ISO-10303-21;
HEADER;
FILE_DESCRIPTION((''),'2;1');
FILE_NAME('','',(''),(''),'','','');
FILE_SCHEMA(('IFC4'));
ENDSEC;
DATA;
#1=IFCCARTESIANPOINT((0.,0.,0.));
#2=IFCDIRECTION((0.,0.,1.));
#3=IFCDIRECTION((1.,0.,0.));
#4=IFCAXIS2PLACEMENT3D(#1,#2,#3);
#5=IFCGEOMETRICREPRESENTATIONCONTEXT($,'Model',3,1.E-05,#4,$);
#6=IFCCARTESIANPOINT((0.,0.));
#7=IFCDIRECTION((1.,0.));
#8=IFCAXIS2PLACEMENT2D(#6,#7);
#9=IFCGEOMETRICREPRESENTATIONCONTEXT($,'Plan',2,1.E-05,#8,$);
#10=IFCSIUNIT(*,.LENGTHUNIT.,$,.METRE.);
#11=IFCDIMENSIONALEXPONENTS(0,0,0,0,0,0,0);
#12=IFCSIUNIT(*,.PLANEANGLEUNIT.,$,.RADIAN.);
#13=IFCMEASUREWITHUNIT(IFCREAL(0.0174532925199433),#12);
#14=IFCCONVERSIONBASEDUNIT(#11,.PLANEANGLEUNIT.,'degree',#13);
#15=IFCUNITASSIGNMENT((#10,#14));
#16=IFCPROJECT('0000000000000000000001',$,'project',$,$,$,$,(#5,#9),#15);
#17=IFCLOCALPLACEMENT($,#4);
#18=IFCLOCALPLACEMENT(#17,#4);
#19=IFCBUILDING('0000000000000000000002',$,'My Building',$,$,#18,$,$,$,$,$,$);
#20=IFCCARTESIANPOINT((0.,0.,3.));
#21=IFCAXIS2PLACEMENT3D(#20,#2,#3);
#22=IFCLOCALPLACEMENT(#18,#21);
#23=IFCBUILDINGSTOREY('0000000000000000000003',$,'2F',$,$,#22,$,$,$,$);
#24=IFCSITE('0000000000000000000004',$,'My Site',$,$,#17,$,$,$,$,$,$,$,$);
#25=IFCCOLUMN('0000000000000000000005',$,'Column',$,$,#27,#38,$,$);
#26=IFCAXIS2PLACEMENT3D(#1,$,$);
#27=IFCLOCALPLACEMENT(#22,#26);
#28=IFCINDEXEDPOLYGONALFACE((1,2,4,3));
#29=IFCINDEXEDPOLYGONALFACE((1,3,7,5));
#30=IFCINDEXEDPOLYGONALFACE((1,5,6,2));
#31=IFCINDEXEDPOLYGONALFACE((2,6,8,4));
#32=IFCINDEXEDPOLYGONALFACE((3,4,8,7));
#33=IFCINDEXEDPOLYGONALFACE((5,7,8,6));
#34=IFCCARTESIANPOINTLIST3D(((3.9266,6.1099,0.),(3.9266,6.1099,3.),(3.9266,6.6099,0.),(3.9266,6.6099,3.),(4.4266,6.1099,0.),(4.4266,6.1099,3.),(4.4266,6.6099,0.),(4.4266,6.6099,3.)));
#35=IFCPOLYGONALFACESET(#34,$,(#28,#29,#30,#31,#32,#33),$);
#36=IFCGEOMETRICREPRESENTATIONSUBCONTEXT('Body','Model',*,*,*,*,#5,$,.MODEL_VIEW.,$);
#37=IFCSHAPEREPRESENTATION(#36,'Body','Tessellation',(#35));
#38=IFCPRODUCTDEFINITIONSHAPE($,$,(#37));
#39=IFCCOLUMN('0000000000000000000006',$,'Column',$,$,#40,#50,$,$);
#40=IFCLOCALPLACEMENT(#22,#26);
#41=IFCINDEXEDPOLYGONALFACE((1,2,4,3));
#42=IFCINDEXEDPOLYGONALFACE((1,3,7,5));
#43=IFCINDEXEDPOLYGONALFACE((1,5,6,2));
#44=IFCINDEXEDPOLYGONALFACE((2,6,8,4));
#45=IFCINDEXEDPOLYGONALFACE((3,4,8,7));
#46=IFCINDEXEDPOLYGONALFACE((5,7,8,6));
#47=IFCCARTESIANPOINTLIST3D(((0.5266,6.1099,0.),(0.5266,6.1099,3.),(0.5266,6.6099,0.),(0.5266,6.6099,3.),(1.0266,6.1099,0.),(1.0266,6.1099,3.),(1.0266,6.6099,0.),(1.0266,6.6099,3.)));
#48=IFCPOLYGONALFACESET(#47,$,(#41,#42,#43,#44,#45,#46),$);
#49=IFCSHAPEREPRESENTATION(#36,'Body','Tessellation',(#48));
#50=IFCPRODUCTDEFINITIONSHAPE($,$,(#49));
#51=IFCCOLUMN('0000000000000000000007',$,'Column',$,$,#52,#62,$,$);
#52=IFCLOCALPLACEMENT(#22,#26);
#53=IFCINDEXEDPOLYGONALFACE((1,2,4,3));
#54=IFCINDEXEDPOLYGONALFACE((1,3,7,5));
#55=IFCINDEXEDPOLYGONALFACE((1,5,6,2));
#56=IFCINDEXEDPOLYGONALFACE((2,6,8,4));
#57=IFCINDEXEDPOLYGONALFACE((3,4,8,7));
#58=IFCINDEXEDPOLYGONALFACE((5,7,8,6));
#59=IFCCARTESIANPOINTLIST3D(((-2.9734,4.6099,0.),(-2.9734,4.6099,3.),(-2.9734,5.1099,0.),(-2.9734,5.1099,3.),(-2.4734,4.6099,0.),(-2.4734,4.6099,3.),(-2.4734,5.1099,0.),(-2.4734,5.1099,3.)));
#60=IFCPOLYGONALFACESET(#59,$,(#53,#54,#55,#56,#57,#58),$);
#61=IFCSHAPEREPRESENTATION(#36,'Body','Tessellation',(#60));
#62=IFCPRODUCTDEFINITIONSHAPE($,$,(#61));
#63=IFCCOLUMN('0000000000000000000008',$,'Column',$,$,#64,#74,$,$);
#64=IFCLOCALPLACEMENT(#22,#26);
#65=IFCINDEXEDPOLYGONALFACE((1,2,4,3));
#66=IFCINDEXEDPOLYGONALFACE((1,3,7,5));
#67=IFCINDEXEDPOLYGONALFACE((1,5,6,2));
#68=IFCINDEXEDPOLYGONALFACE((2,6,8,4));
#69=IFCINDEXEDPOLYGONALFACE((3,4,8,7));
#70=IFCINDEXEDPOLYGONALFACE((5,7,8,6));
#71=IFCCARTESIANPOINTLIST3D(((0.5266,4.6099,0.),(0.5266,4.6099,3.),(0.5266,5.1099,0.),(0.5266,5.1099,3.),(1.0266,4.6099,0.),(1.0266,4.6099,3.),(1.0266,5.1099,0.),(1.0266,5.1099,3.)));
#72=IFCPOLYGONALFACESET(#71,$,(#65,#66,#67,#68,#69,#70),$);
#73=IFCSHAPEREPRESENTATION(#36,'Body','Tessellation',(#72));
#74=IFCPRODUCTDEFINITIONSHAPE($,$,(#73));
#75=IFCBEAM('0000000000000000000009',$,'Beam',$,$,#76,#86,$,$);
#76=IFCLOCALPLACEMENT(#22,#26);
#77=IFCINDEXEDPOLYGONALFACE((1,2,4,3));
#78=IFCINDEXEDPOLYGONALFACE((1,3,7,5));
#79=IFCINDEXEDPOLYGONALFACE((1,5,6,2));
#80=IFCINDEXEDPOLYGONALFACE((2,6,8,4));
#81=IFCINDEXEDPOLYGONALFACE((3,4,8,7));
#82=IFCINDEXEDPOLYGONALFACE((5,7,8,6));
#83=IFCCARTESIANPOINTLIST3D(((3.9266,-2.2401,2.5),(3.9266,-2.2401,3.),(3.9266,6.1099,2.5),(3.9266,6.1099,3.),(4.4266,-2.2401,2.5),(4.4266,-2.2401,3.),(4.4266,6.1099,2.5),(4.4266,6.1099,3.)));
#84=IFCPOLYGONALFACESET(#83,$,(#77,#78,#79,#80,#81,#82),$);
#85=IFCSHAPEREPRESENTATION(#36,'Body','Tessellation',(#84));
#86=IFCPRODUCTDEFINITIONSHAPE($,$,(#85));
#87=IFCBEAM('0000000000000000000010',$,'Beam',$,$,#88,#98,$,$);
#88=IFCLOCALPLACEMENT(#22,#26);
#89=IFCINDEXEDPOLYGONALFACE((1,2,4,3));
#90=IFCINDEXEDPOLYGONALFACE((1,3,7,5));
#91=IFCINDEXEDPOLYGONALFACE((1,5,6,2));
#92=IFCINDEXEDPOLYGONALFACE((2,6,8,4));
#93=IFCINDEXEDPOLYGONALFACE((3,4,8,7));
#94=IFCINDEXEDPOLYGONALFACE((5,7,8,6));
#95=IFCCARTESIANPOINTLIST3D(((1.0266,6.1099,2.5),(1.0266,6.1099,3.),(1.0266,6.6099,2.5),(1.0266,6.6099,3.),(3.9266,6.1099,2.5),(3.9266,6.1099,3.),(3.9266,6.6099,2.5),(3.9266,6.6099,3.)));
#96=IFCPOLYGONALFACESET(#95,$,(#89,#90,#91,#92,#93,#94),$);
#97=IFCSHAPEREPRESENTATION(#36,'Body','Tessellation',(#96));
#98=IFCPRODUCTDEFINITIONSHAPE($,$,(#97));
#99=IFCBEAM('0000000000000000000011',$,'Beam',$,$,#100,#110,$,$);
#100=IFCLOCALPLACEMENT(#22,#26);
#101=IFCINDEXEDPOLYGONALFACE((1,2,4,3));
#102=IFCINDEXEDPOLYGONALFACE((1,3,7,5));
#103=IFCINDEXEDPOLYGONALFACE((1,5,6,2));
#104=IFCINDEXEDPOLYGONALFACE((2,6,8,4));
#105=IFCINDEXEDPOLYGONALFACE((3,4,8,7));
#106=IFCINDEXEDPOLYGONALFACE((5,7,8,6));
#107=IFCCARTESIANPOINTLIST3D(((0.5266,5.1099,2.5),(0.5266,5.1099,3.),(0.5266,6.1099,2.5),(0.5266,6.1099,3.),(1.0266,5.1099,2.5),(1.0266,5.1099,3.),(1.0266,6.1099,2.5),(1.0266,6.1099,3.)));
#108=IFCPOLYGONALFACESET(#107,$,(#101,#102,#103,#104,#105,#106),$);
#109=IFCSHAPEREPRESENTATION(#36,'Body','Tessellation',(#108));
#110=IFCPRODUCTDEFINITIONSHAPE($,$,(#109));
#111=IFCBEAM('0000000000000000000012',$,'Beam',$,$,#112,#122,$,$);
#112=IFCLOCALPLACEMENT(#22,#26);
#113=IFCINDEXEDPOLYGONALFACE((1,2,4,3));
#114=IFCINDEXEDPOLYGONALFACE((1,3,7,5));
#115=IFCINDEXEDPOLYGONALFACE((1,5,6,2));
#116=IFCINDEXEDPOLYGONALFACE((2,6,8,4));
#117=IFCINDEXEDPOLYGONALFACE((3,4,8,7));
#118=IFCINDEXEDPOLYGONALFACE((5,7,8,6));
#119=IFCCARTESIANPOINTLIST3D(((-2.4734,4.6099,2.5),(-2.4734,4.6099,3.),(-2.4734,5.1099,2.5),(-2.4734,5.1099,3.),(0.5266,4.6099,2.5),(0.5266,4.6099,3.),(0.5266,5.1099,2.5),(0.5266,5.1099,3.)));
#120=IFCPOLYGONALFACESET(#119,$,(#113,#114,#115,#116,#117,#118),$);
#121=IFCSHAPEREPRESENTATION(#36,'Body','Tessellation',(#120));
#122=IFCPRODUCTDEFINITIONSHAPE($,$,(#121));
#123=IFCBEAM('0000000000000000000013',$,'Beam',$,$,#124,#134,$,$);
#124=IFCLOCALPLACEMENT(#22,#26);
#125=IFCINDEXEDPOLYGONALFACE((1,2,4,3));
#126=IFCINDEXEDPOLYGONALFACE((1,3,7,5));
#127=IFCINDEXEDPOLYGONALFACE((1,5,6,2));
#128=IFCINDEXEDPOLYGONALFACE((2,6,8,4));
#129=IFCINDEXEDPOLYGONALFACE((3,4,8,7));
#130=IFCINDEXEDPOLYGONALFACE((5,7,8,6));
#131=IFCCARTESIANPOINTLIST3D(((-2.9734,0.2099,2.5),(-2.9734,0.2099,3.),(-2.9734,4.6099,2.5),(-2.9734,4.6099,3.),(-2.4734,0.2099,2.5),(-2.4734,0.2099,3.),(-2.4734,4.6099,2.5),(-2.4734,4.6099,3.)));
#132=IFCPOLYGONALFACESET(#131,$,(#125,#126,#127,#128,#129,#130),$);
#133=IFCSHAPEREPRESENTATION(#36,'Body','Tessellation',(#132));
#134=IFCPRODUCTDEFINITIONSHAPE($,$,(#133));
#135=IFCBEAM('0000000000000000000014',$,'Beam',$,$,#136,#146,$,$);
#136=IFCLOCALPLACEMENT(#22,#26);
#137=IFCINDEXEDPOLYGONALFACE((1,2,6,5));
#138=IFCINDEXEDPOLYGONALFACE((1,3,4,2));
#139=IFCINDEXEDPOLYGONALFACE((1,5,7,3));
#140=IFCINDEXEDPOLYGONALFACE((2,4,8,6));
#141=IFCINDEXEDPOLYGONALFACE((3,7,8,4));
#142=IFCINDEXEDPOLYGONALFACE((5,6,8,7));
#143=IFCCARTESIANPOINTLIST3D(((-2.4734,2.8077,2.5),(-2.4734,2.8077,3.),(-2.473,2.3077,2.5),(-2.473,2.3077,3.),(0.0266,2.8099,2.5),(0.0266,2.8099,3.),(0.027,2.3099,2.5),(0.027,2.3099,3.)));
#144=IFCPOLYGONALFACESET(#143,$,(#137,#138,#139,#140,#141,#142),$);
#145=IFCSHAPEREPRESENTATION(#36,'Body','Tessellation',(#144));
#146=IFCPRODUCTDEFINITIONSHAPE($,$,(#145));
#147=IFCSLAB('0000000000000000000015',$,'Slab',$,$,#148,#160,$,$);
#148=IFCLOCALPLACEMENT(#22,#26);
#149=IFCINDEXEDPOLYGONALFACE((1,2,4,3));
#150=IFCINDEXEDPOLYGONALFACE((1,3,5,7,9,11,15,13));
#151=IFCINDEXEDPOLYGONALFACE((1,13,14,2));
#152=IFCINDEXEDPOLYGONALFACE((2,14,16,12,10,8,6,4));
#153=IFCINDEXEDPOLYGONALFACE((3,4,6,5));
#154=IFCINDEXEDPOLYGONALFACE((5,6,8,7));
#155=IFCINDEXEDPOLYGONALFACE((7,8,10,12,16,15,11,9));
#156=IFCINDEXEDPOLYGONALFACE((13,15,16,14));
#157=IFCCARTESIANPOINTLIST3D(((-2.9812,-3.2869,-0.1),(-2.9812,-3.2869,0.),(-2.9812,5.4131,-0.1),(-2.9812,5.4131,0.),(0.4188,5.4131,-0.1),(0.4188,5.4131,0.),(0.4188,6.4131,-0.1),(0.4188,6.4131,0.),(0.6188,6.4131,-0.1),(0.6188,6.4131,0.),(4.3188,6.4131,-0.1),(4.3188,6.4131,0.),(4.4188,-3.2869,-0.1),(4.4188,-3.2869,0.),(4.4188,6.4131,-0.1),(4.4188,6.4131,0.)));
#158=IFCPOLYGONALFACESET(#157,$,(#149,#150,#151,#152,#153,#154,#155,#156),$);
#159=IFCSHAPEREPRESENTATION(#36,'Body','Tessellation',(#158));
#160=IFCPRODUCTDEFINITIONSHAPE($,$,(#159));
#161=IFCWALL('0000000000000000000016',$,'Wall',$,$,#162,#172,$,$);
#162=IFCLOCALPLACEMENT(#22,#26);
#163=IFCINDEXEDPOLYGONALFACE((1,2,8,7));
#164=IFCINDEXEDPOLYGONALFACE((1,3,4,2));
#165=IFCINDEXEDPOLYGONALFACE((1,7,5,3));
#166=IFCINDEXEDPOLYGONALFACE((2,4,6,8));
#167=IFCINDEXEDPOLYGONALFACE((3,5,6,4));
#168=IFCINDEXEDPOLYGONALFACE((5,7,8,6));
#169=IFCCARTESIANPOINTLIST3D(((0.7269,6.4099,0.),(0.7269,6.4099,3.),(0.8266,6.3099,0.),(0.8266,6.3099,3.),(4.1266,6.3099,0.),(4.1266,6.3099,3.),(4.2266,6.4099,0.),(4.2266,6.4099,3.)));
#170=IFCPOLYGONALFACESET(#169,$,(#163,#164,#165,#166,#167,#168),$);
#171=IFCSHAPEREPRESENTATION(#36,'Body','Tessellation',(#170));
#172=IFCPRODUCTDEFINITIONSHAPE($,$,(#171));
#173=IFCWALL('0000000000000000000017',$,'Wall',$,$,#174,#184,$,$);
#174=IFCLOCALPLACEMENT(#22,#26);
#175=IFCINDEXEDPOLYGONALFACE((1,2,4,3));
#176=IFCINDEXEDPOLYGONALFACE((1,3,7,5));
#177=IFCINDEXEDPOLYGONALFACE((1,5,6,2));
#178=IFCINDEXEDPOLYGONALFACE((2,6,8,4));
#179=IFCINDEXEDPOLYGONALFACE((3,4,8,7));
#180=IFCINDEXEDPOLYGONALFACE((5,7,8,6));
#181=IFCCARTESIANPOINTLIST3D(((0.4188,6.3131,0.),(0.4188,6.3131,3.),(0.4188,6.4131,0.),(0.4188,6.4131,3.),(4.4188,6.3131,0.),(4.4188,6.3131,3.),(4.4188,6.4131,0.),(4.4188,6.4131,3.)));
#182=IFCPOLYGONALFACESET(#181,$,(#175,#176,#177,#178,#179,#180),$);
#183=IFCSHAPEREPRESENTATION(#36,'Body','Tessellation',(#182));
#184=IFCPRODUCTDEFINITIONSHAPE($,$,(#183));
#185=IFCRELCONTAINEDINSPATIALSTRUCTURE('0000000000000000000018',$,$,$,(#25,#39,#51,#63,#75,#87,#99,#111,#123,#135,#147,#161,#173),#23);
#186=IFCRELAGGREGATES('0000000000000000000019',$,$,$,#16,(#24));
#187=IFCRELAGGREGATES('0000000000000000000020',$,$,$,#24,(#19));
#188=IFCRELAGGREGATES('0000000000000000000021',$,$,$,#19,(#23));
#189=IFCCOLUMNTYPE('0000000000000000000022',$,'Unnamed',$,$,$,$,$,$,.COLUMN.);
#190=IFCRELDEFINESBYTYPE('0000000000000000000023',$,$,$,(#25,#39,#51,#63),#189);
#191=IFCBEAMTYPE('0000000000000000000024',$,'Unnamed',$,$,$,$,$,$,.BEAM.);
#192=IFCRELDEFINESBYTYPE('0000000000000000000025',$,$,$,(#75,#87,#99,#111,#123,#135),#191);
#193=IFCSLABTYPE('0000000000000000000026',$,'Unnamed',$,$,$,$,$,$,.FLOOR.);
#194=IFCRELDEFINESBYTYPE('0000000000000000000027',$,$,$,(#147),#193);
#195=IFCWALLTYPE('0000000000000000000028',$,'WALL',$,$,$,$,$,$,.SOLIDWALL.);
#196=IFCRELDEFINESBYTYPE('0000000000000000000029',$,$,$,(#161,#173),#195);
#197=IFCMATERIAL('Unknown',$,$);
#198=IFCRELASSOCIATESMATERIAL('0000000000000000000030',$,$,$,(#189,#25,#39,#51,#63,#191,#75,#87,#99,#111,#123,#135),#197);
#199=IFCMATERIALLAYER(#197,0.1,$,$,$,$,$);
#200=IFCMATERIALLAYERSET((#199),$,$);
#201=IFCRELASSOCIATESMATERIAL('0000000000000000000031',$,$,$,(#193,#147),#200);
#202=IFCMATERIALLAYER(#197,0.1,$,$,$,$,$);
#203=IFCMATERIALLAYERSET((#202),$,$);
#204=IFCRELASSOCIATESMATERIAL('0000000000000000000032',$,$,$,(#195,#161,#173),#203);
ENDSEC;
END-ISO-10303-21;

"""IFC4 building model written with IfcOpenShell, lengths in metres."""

from ifc_helpers import new_model, entity, si_unit, converted_unit, frame, origin_with_axes, origin_2d_with_axis, place, context, subcontext, project, spatial, line, indexed_curve, rectangle, outline, extrude, material, layer, layer_set, layer_usage, material_profile, profile_set, profile_usage, type_object, element, save


model = new_model("IFC4")

# Units and contexts
model_context = context("Model", 3, precision=1e-05, world=origin_with_axes())
plan_context = context("Plan", 2, precision=1e-05, world=origin_2d_with_axis())
body_context_1 = subcontext(model_context, "Body", "Model", "MODEL_VIEW")
ifc_project = project(units=[si_unit("LENGTHUNIT", "METRE"), converted_unit("PLANEANGLEUNIT", "degree", entity("IfcReal", 0.0174532925199433), si_unit("PLANEANGLEUNIT", "RADIAN"), dimensions=[0, 0, 0, 0, 0, 0, 0])], contexts=[model_context, plan_context])

# Site, building, storey
site_placement = place(None, origin_with_axes())
site = spatial("IfcSite", under=ifc_project, at=site_placement, Name="My Site")
building_placement = place(site_placement, origin_with_axes())
building = spatial("IfcBuilding", under=site, at=building_placement, Name="My Building")
storey_placement = place(building_placement, frame((0.0, 0.0, 3.0), z_axis=(0.0, 0.0, 1.0), x_axis=(1.0, 0.0, 0.0)))
storey = spatial("IfcBuildingStorey", under=building, at=storey_placement, Name="2F")

# Columns
ifc_material = material(Name="Unknown")
ifc_material_profile_1 = material_profile(ifc_material, rectangle(XDim=0.5, YDim=0.5))
ifc_profile_set_1 = profile_set([ifc_material_profile_1])
ifc_profile_usage_1 = profile_usage(ifc_profile_set_1, cardinal=5)
column_type = type_object("IfcColumnType", Name="Unnamed", PredefinedType="COLUMN", material=ifc_profile_set_1)
column_1_placement = place(storey_placement, frame((4.1766, 6.3599, 0.0), z_axis=(0.0, 0.0, 1.0), x_axis=(1.0, 0.0, 0.0)))
element("IfcColumn", 1, at=column_1_placement, inside=storey, type_object=column_type, material=ifc_profile_usage_1, Name="Column", context=body_context_1, shape_type="SweptSolid", body=[
    extrude(rectangle(XDim=0.5, YDim=0.5), origin_with_axes(), (0.0, 0.0, 1.0), 3.0),
])
ifc_profile_usage_2 = profile_usage(ifc_profile_set_1, cardinal=5)
column_2_placement = place(storey_placement, frame((0.7766, 6.3599, 0.0), z_axis=(0.0, 0.0, 1.0), x_axis=(1.0, 0.0, 0.0)))
element("IfcColumn", 2, at=column_2_placement, inside=storey, type_object=column_type, material=ifc_profile_usage_2, Name="Column", context=body_context_1, shape_type="SweptSolid", body=[
    extrude(rectangle(XDim=0.5, YDim=0.5), origin_with_axes(), (0.0, 0.0, 1.0), 3.0),
])
ifc_profile_usage_3 = profile_usage(ifc_profile_set_1, cardinal=5)
column_3_placement = place(storey_placement, frame((-2.7234, 4.8599, 0.0), z_axis=(0.0, 0.0, 1.0), x_axis=(1.0, 0.0, 0.0)))
element("IfcColumn", 3, at=column_3_placement, inside=storey, type_object=column_type, material=ifc_profile_usage_3, Name="Column", context=body_context_1, shape_type="SweptSolid", body=[
    extrude(rectangle(XDim=0.5, YDim=0.5), origin_with_axes(), (0.0, 0.0, 1.0), 3.0),
])
ifc_profile_usage_4 = profile_usage(ifc_profile_set_1, cardinal=5)
column_4_placement = place(storey_placement, frame((0.7766, 4.8599, 0.0), z_axis=(0.0, 0.0, 1.0), x_axis=(1.0, 0.0, 0.0)))
element("IfcColumn", 4, at=column_4_placement, inside=storey, type_object=column_type, material=ifc_profile_usage_4, Name="Column", context=body_context_1, shape_type="SweptSolid", body=[
    extrude(rectangle(XDim=0.5, YDim=0.5), origin_with_axes(), (0.0, 0.0, 1.0), 3.0),
])

# Beams
ifc_material_profile_2 = material_profile(ifc_material, rectangle(XDim=0.5, YDim=0.5))
ifc_profile_set_2 = profile_set([ifc_material_profile_2])
ifc_profile_usage_5 = profile_usage(ifc_profile_set_2, cardinal=9)
beam_type = type_object("IfcBeamType", Name="Unnamed", PredefinedType="BEAM", material=ifc_profile_set_2)
beam_1_placement = place(storey_placement, frame((3.9266, 6.1099, 3.0), z_axis=(0.0, -1.0, 0.0), x_axis=(1.0, 0.0, 0.0)))
element("IfcBeam", 5, at=beam_1_placement, inside=storey, type_object=beam_type, material=ifc_profile_usage_5, Name="Beam", context=body_context_1, shape_type="SweptSolid", body=[
    extrude(rectangle(XDim=0.5, YDim=0.5), frame((0.25, -0.25, 0.0), z_axis=(0.0, 0.0, 1.0), x_axis=(1.0, 0.0, 0.0)), (0.0, 0.0, 1.0), 8.35),
])
ifc_profile_usage_6 = profile_usage(ifc_profile_set_2, cardinal=7)
beam_2_placement = place(storey_placement, frame((1.0266, 6.6099, 3.0), z_axis=(1.0, -0.000001, 0.0), x_axis=(0.000001, 1.0, 0.0)))
element("IfcBeam", 6, at=beam_2_placement, inside=storey, type_object=beam_type, material=ifc_profile_usage_6, Name="Beam", context=body_context_1, shape_type="SweptSolid", body=[
    extrude(rectangle(XDim=0.5, YDim=0.5), frame((-0.25, -0.25, 0.0), z_axis=(0.0, 0.0, 1.0), x_axis=(1.0, 0.0, 0.0)), (0.0, 0.0, 1.0), 2.9),
])
ifc_profile_usage_7 = profile_usage(ifc_profile_set_2, cardinal=7)
beam_3_placement = place(storey_placement, frame((1.0266, 6.1099, 3.0), z_axis=(0.0, -1.0, 0.0), x_axis=(1.0, 0.0, 0.0)))
element("IfcBeam", 7, at=beam_3_placement, inside=storey, type_object=beam_type, material=ifc_profile_usage_7, Name="Beam", context=body_context_1, shape_type="SweptSolid", body=[
    extrude(rectangle(XDim=0.5, YDim=0.5), frame((-0.25, -0.25, 0.0), z_axis=(0.0, 0.0, 1.0), x_axis=(1.0, 0.0, 0.0)), (0.0, 0.0, 1.0), 1.0),
])
ifc_profile_usage_8 = profile_usage(ifc_profile_set_2, cardinal=7)
beam_4_placement = place(storey_placement, frame((-2.4734, 5.1099, 3.0), z_axis=(1.0, -0.000001, 0.0), x_axis=(0.000001, 1.0, 0.0)))
element("IfcBeam", 8, at=beam_4_placement, inside=storey, type_object=beam_type, material=ifc_profile_usage_8, Name="Beam", context=body_context_1, shape_type="SweptSolid", body=[
    extrude(rectangle(XDim=0.5, YDim=0.5), frame((-0.25, -0.25, 0.0), z_axis=(0.0, 0.0, 1.0), x_axis=(1.0, 0.0, 0.0)), (0.0, 0.0, 1.0), 3.0),
])
ifc_profile_usage_9 = profile_usage(ifc_profile_set_2, cardinal=7)
beam_5_placement = place(storey_placement, frame((-2.4734, 4.6099, 3.0), z_axis=(0.0, -1.0, 0.0), x_axis=(1.0, 0.0, 0.0)))
element("IfcBeam", 9, at=beam_5_placement, inside=storey, type_object=beam_type, material=ifc_profile_usage_9, Name="Beam", context=body_context_1, shape_type="SweptSolid", body=[
    extrude(rectangle(XDim=0.5, YDim=0.5), frame((-0.25, -0.25, 0.0), z_axis=(0.0, 0.0, 1.0), x_axis=(1.0, 0.0, 0.0)), (0.0, 0.0, 1.0), 4.4),
])
ifc_profile_usage_10 = profile_usage(ifc_profile_set_2, cardinal=7)
beam_6_placement = place(storey_placement, frame((-2.4734, 2.8077, 3.0), z_axis=(1.0, 0.000853, 0.0), x_axis=(-0.000853, 1.0, 0.0)))
element("IfcBeam", 10, at=beam_6_placement, inside=storey, type_object=beam_type, material=ifc_profile_usage_10, Name="Beam", context=body_context_1, shape_type="SweptSolid", body=[
    extrude(rectangle(XDim=0.5, YDim=0.5), frame((-0.25, -0.25, 0.0), z_axis=(0.0, 0.0, 1.0), x_axis=(1.0, 0.0, 0.0)), (0.0, 0.0, 1.0), 2.5),
])

# Slab
ifc_layer_1 = layer(ifc_material, 0.1)
ifc_layer_set_1 = layer_set([ifc_layer_1])
ifc_layer_usage_1 = layer_usage(ifc_layer_set_1, "AXIS3", "POSITIVE", -0.1)
slab_type = type_object("IfcSlabType", Name="Unnamed", PredefinedType="FLOOR", material=ifc_layer_set_1)
slab_placement = place(storey_placement, frame((0.6188, 6.4131, 0.0), z_axis=(0.0, 0.0, 1.0), x_axis=(1.0, 0.0, 0.0)))
element("IfcSlab", 11, at=slab_placement, inside=storey, type_object=slab_type, material=ifc_layer_usage_1, Name="Slab", context=body_context_1, shape_type="SweptSolid", body=[
    extrude(outline(indexed_curve([(0.0, 0.0), (3.7, 0.0), (3.8, 0.0), (3.8, -9.7), (-3.6, -9.7), (-3.6, -1.0), (-0.2, -1.0), (-0.2, 0.0), (0.0, 0.0)])), frame((0.0, 0.0, -0.1), z_axis=(0.0, 0.0, 1.0), x_axis=(1.0, 0.0, 0.0)), (0.0, 0.0, 1.0), 0.1),
])

# Walls
ifc_layer_2 = layer(ifc_material, 0.1)
ifc_layer_set_2 = layer_set([ifc_layer_2])
ifc_layer_usage_2 = layer_usage(ifc_layer_set_2, "AXIS2", "POSITIVE", 0.0)
wall_type = type_object("IfcWallType", Name="WALL", PredefinedType="SOLIDWALL", material=ifc_layer_set_2)
wall_1_placement = place(storey_placement, frame((0.8266, 6.3099, 0.0), z_axis=(0.0, 0.0, 1.0), x_axis=(1.0, 0.0, 0.0)))
element("IfcWall", 12, at=wall_1_placement, inside=storey, type_object=wall_type, material=ifc_layer_usage_2, Name="Wall", context=body_context_1, shape_type="SweptSolid", body=[
    extrude(outline(indexed_curve([(0.0, 0.0), (-0.0997, 0.1), (3.4, 0.1), (3.3, 0.0)], segments=[line(1, 2, 3, 4, 1)])), origin_with_axes(), (0.0, 0.0, 1.0), 3.0),
])
ifc_layer_usage_3 = layer_usage(ifc_layer_set_2, "AXIS2", "POSITIVE", 0.0)
wall_2_placement = place(storey_placement, frame((0.4188, 6.3131, 0.0), z_axis=(0.0, 0.0, 1.0), x_axis=(1.0, 0.0, 0.0)))
element("IfcWall", 13, at=wall_2_placement, inside=storey, type_object=wall_type, material=ifc_layer_usage_3, Name="Wall", context=body_context_1, shape_type="SweptSolid", body=[
    extrude(outline(indexed_curve([(0.0, 0.0), (0.0, 0.1), (4.0, 0.1), (4.0, 0.0)], segments=[line(1, 2, 3, 4, 1)])), origin_with_axes(), (0.0, 0.0, 1.0), 3.0),
])

save(model, "model.ifc")
